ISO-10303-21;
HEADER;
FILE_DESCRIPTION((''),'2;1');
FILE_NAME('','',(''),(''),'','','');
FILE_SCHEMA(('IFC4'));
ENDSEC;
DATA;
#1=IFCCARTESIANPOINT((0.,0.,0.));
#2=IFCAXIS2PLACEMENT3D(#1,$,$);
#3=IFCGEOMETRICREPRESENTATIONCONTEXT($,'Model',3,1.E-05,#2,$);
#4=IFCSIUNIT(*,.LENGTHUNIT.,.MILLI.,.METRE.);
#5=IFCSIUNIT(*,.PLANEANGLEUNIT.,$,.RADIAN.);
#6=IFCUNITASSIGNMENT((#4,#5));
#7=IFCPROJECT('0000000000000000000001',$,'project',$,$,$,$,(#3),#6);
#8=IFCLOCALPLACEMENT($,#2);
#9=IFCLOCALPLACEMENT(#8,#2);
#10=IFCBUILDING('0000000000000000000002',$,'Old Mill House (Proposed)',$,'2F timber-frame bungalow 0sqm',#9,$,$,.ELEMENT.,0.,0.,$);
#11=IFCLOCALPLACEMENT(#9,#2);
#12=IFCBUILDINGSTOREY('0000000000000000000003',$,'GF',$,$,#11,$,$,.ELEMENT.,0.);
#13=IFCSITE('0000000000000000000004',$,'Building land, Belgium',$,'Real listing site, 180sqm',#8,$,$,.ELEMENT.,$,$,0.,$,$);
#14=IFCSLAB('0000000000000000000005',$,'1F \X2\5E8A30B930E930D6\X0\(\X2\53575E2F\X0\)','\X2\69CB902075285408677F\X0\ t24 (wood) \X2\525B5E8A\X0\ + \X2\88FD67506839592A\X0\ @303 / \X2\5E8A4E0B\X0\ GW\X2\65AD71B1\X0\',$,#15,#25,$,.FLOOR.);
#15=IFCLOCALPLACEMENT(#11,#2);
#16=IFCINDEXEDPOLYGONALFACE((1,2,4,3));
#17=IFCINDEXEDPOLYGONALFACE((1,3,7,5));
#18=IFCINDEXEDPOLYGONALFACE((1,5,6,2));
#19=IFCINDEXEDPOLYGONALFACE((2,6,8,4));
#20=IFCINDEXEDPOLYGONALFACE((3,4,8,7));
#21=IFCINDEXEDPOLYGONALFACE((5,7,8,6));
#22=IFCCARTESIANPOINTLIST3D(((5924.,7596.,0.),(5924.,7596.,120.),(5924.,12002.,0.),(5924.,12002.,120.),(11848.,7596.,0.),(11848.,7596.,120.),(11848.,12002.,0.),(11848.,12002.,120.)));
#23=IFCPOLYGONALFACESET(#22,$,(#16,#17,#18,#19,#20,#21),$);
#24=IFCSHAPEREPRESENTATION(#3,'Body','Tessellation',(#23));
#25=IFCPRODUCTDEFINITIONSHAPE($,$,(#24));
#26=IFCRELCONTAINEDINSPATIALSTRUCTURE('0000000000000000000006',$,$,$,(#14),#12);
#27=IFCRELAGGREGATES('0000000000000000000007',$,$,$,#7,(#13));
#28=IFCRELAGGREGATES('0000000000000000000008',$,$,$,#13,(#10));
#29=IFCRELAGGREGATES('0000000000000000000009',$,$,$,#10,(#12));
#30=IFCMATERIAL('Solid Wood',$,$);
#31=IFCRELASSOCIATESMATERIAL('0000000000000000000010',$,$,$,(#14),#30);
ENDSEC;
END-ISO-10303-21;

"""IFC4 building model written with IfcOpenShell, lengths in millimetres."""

from ifc_helpers import new_model, si_unit, frame, frame_2d, origin, place, context, project, spatial, rectangle, extrude, material, element, save


model = new_model("IFC4")

# Units and contexts
model_context = context("Model", 3, precision=1e-05, world=origin())
ifc_project = project(units=[si_unit("LENGTHUNIT", "METRE", prefix="MILLI"), si_unit("PLANEANGLEUNIT", "RADIAN")], contexts=[model_context])

# Site, building, storey
site_placement = place(None, origin())
site = spatial("IfcSite", under=ifc_project, at=site_placement, Name="Building land, Belgium", ObjectType="Real listing site, 180sqm", CompositionType="ELEMENT", RefElevation=0.0)
building_placement = place(site_placement, origin())
building = spatial("IfcBuilding", under=site, at=building_placement, Name="Old Mill House (Proposed)", ObjectType="2F timber-frame bungalow 0sqm", CompositionType="ELEMENT", ElevationOfRefHeight=0.0, ElevationOfTerrain=0.0)
storey_placement = place(building_placement, origin())
storey = spatial("IfcBuildingStorey", under=building, at=storey_placement, Name="GF", CompositionType="ELEMENT", Elevation=0.0)

# Slab
ifc_material_1 = material(Name="Solid Wood")
slab_1_placement = place(storey_placement, frame((2962.0, 3798.0, 0.0)))
element("IfcSlab", 1, at=slab_1_placement, inside=storey, material=ifc_material_1, Name="1F 床スラブ(南帯)", Description="構造用合板 t24 (wood) 剛床 + 製材根太 @303 / 床下 GW断熱", PredefinedType="FLOOR", context=model_context, shape_type="SweptSolid", body=[
    extrude(rectangle(XDim=5924.0, YDim=4406.0, at=frame_2d((2962.0, 2203.0))), frame((2962.0, 3798.0, 0.0)), (0.0, 0.0, 1.0), 120.0),
])

save(model, "model.ifc")
